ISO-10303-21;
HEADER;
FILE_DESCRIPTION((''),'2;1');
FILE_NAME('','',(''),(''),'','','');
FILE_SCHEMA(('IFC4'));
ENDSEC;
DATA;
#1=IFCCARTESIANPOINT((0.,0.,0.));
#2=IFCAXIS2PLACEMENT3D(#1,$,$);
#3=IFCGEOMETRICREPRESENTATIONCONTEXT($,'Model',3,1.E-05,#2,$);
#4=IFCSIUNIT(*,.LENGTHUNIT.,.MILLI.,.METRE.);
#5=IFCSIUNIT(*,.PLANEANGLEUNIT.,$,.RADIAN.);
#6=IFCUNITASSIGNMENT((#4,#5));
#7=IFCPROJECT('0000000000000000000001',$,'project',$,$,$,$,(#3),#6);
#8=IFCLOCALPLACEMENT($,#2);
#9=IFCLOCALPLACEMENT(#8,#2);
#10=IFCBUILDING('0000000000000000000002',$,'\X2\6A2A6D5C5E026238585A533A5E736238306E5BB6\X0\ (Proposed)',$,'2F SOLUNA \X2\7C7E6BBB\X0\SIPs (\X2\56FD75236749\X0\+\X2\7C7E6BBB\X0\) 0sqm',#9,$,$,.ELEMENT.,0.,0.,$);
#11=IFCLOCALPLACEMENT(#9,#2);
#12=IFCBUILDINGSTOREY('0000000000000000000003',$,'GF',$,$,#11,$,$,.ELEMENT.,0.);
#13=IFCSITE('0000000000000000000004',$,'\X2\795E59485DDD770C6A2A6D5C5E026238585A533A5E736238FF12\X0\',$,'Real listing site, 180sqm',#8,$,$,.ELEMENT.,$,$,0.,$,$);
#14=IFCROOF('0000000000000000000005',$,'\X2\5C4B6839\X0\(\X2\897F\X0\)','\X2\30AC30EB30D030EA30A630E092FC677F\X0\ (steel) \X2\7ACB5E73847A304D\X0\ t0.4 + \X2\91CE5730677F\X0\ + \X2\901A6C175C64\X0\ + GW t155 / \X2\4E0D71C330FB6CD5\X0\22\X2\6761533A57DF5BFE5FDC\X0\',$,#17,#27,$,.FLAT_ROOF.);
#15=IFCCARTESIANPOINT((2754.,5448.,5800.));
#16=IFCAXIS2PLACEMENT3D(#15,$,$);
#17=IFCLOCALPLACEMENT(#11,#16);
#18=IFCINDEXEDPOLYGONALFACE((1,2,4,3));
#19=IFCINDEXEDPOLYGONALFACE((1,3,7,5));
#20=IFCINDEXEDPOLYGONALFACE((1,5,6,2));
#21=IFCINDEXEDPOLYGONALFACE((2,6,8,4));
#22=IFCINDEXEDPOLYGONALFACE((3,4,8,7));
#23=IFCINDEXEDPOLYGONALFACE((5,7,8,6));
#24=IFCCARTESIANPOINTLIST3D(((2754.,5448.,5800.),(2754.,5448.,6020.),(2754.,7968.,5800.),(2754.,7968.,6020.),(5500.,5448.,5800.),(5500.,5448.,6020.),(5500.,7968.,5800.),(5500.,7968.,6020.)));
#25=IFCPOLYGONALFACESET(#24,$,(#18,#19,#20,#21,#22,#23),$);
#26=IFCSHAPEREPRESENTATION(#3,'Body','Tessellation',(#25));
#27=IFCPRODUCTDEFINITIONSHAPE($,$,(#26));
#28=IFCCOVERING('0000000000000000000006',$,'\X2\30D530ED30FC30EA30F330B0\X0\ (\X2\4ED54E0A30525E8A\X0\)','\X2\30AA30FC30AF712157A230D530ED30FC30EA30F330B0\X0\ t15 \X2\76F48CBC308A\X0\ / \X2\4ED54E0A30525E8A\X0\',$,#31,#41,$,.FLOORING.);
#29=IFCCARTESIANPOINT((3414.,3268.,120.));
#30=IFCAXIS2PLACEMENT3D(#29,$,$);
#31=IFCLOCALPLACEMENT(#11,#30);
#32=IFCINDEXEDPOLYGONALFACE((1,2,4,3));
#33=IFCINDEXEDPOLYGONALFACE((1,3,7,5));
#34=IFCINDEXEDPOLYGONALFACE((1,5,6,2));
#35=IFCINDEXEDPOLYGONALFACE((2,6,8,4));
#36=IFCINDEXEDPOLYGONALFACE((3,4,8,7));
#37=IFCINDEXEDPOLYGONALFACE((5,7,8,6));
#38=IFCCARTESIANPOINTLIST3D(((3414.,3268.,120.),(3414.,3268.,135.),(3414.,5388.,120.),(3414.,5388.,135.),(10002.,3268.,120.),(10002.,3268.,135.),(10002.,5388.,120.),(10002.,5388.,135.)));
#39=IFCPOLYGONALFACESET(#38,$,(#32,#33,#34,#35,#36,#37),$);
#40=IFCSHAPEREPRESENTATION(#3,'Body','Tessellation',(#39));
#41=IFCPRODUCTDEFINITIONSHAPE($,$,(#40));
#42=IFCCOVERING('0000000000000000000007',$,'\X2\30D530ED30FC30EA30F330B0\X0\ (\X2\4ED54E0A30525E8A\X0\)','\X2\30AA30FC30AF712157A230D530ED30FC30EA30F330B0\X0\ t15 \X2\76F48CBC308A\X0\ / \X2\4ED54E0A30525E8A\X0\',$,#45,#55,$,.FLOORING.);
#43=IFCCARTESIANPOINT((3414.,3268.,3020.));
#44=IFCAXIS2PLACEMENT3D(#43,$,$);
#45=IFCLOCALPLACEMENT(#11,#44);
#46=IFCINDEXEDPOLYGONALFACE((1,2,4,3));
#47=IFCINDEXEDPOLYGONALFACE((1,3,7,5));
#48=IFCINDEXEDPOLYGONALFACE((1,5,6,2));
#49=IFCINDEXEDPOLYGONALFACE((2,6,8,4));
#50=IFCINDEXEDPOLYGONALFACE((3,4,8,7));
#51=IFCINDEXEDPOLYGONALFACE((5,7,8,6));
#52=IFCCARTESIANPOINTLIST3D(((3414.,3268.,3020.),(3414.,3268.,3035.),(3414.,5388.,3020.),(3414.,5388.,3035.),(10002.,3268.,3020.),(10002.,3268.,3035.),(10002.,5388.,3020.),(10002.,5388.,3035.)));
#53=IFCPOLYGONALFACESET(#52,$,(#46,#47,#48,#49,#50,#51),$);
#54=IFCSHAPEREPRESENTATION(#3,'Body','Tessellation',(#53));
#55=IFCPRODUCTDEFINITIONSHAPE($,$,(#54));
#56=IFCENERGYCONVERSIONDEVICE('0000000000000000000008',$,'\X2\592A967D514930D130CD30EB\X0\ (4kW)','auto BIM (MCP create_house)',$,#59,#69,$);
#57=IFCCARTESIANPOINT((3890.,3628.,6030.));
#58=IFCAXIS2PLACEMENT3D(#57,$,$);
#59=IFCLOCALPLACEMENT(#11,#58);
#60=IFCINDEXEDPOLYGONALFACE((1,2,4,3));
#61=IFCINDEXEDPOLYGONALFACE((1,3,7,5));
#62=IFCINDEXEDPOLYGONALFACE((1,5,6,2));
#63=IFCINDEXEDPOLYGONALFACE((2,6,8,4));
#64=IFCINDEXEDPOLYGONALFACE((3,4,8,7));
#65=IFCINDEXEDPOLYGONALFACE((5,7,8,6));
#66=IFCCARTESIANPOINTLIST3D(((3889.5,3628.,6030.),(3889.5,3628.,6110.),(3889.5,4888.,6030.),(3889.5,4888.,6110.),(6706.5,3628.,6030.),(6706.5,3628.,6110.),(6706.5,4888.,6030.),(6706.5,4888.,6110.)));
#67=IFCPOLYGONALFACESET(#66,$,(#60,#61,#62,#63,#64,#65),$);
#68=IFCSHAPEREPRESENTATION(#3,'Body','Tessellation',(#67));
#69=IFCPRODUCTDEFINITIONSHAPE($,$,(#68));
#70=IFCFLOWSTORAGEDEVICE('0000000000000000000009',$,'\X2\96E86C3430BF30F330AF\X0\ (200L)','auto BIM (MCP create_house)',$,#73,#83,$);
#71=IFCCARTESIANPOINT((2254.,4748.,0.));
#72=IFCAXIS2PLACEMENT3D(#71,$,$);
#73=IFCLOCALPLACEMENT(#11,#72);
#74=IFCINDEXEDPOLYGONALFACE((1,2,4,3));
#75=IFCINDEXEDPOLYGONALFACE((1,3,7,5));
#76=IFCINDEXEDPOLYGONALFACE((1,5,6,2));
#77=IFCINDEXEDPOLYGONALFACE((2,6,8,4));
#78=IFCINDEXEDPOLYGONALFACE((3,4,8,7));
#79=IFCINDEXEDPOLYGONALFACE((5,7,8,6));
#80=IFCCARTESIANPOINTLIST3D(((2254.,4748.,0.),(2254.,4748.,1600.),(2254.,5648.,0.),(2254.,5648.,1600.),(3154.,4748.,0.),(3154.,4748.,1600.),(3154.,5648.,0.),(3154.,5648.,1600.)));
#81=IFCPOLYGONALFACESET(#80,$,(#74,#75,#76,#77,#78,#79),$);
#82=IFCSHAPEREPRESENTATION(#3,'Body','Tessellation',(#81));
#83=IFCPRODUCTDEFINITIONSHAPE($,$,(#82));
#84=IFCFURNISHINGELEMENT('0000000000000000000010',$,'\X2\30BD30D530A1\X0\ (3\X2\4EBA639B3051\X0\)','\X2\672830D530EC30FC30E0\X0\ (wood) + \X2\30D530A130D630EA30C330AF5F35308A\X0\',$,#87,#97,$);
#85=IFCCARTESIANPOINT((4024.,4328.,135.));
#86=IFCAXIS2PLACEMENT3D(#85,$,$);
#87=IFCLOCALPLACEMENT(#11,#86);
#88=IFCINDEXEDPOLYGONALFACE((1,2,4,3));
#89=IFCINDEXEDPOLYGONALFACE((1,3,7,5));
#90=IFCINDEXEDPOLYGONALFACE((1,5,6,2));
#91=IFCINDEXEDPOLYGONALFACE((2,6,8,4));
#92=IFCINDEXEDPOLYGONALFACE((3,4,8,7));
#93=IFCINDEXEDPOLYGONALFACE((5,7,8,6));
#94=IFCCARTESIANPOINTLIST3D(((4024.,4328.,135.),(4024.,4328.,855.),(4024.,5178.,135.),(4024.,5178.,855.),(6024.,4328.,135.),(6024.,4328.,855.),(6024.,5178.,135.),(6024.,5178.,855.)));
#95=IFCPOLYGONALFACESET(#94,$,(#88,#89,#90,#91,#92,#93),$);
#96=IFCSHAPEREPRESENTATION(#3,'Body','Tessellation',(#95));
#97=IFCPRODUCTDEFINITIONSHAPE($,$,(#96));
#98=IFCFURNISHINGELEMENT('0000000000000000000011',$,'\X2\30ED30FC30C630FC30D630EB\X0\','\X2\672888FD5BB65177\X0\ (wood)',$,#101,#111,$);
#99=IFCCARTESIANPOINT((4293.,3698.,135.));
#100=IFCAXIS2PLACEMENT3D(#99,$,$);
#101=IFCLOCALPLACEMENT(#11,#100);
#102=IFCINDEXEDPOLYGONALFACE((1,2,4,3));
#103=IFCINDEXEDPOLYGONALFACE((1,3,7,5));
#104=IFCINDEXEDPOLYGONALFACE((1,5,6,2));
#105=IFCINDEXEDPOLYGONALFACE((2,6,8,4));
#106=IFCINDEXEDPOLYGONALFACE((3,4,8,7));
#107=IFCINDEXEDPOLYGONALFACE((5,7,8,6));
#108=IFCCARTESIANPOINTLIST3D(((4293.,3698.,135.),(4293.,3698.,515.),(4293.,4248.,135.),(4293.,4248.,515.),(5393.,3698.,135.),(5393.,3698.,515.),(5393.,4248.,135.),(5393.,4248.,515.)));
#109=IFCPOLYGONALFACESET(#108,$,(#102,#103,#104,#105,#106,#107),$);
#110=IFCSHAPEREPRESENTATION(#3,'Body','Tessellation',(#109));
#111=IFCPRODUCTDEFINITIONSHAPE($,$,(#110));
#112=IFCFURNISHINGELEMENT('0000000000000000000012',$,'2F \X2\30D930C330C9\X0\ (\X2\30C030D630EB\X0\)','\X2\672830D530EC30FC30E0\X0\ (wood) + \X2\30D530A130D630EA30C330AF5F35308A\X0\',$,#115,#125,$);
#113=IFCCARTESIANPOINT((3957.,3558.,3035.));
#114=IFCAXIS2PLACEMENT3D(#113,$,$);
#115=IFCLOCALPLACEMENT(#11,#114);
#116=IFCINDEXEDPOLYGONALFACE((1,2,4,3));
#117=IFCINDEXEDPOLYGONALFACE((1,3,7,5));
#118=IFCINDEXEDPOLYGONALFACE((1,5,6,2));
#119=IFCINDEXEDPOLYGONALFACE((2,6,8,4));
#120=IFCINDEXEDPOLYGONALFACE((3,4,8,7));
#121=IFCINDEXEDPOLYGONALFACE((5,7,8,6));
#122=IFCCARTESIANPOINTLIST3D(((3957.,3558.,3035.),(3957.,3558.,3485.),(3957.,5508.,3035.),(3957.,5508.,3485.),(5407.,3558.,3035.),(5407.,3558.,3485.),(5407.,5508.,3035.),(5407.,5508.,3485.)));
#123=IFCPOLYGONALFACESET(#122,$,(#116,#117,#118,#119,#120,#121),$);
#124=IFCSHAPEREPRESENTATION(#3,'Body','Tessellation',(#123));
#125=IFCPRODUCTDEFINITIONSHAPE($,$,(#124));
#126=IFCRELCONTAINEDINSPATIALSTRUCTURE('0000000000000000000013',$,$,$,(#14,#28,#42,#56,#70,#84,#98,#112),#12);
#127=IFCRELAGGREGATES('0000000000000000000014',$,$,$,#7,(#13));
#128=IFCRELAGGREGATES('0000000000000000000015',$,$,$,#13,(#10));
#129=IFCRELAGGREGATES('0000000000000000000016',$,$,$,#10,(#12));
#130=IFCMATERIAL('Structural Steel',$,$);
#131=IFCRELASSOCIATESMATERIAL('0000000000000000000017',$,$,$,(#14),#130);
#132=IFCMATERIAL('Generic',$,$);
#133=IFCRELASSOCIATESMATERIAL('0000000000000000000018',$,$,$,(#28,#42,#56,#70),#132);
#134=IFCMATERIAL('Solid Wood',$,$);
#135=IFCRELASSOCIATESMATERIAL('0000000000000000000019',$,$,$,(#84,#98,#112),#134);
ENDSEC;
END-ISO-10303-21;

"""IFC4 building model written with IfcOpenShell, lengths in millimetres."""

from ifc_helpers import new_model, si_unit, frame, frame_2d, origin, place, context, project, spatial, rectangle, extrude, material, element, save


model = new_model("IFC4")

# Units and contexts
model_context = context("Model", 3, precision=1e-05, world=origin())
ifc_project = project(units=[si_unit("LENGTHUNIT", "METRE", prefix="MILLI"), si_unit("PLANEANGLEUNIT", "RADIAN")], contexts=[model_context])

# Site, building, storey
site_placement = place(None, origin())
site = spatial("IfcSite", under=ifc_project, at=site_placement, Name="神奈川県横浜市戸塚区平戸２", ObjectType="Real listing site, 180sqm", CompositionType="ELEMENT", RefElevation=0.0)
building_placement = place(site_placement, origin())
building = spatial("IfcBuilding", under=site, at=building_placement, Name="横浜市戸塚区平戸の家 (Proposed)", ObjectType="2F SOLUNA 籾殻SIPs (国産杉+籾殻) 0sqm", CompositionType="ELEMENT", ElevationOfRefHeight=0.0, ElevationOfTerrain=0.0)
storey_placement = place(building_placement, origin())
storey = spatial("IfcBuildingStorey", under=building, at=storey_placement, Name="GF", CompositionType="ELEMENT", Elevation=0.0)

# Shared definitions
ifc_material_1 = material(Name="Solid Wood")

# Roof
ifc_material_2 = material(Name="Structural Steel")
roof_1_placement = place(storey_placement, frame((2754.0, 5448.0, 5800.0)))
element("IfcRoof", 1, at=roof_1_placement, inside=storey, material=ifc_material_2, Name="屋根(西)", Description="ガルバリウム鋼板 (steel) 立平葺き t0.4 + 野地板 + 通気層 + GW t155 / 不燃・法22条区域対応", PredefinedType="FLAT_ROOF", context=model_context, shape_type="SweptSolid", body=[
    extrude(rectangle(XDim=2746.0, YDim=2520.0, at=frame_2d((1373.0, 1260.0))), frame((2754.0, 5448.0, 5800.0)), (0.0, 0.0, 1.0), 220.0),
])

# Coverings
ifc_material_3 = material(Name="Generic")
covering_1_placement = place(storey_placement, frame((3414.0, 3268.0, 120.0)))
element("IfcCovering", 2, at=covering_1_placement, inside=storey, material=ifc_material_3, Name="フローリング (仕上げ床)", Description="オーク無垢フローリング t15 直貼り / 仕上げ床", PredefinedType="FLOORING", context=model_context, shape_type="SweptSolid", body=[
    extrude(rectangle(XDim=6588.0, YDim=2120.0, at=frame_2d((3294.0, 1060.0))), frame((3414.0, 3268.0, 120.0)), (0.0, 0.0, 1.0), 15.0),
])
covering_2_placement = place(storey_placement, frame((3414.0, 3268.0, 3020.0)))
element("IfcCovering", 3, at=covering_2_placement, inside=storey, material=ifc_material_3, Name="フローリング (仕上げ床)", Description="オーク無垢フローリング t15 直貼り / 仕上げ床", PredefinedType="FLOORING", context=model_context, shape_type="SweptSolid", body=[
    extrude(rectangle(XDim=6588.0, YDim=2120.0, at=frame_2d((3294.0, 1060.0))), frame((3414.0, 3268.0, 3020.0)), (0.0, 0.0, 1.0), 15.0),
])

# Energy conversion device
energy_conversion_device_placement = place(storey_placement, frame((3890.0, 3628.0, 6030.0)))
element("IfcEnergyConversionDevice", 4, at=energy_conversion_device_placement, inside=storey, material=ifc_material_3, Name="太陽光パネル (4kW)", Description="auto BIM (MCP create_house)", context=model_context, shape_type="SweptSolid", body=[
    extrude(rectangle(XDim=2817.0, YDim=1260.0, at=frame_2d((1408.0, 630.0))), frame((3890.0, 3628.0, 6030.0)), (0.0, 0.0, 1.0), 80.0),
])

# Flow storage device
flow_storage_device_placement = place(storey_placement, frame((2254.0, 4748.0, 0.0)))
element("IfcFlowStorageDevice", 5, at=flow_storage_device_placement, inside=storey, material=ifc_material_3, Name="雨水タンク (200L)", Description="auto BIM (MCP create_house)", context=model_context, shape_type="SweptSolid", body=[
    extrude(rectangle(XDim=900.0, YDim=900.0, at=frame_2d((450.0, 450.0))), frame((2254.0, 4748.0, 0.0)), (0.0, 0.0, 1.0), 1600.0),
])

# Furnishing elements
furnishing_1_placement = place(storey_placement, frame((4024.0, 4328.0, 135.0)))
element("IfcFurnishingElement", 6, at=furnishing_1_placement, inside=storey, material=ifc_material_1, Name="ソファ (3人掛け)", Description="木フレーム (wood) + ファブリック張り", context=model_context, shape_type="SweptSolid", body=[
    extrude(rectangle(XDim=2000.0, YDim=850.0, at=frame_2d((1000.0, 425.0))), frame((4024.0, 4328.0, 135.0)), (0.0, 0.0, 1.0), 720.0),
])
furnishing_2_placement = place(storey_placement, frame((4293.0, 3698.0, 135.0)))
element("IfcFurnishingElement", 7, at=furnishing_2_placement, inside=storey, material=ifc_material_1, Name="ローテーブル", Description="木製家具 (wood)", context=model_context, shape_type="SweptSolid", body=[
    extrude(rectangle(XDim=1100.0, YDim=550.0, at=frame_2d((550.0, 275.0))), frame((4293.0, 3698.0, 135.0)), (0.0, 0.0, 1.0), 380.0),
])
furnishing_3_placement = place(storey_placement, frame((3957.0, 3558.0, 3035.0)))
element("IfcFurnishingElement", 8, at=furnishing_3_placement, inside=storey, material=ifc_material_1, Name="2F ベッド (ダブル)", Description="木フレーム (wood) + ファブリック張り", context=model_context, shape_type="SweptSolid", body=[
    extrude(rectangle(XDim=1450.0, YDim=1950.0, at=frame_2d((725.0, 975.0))), frame((3957.0, 3558.0, 3035.0)), (0.0, 0.0, 1.0), 450.0),
])

save(model, "model.ifc")
